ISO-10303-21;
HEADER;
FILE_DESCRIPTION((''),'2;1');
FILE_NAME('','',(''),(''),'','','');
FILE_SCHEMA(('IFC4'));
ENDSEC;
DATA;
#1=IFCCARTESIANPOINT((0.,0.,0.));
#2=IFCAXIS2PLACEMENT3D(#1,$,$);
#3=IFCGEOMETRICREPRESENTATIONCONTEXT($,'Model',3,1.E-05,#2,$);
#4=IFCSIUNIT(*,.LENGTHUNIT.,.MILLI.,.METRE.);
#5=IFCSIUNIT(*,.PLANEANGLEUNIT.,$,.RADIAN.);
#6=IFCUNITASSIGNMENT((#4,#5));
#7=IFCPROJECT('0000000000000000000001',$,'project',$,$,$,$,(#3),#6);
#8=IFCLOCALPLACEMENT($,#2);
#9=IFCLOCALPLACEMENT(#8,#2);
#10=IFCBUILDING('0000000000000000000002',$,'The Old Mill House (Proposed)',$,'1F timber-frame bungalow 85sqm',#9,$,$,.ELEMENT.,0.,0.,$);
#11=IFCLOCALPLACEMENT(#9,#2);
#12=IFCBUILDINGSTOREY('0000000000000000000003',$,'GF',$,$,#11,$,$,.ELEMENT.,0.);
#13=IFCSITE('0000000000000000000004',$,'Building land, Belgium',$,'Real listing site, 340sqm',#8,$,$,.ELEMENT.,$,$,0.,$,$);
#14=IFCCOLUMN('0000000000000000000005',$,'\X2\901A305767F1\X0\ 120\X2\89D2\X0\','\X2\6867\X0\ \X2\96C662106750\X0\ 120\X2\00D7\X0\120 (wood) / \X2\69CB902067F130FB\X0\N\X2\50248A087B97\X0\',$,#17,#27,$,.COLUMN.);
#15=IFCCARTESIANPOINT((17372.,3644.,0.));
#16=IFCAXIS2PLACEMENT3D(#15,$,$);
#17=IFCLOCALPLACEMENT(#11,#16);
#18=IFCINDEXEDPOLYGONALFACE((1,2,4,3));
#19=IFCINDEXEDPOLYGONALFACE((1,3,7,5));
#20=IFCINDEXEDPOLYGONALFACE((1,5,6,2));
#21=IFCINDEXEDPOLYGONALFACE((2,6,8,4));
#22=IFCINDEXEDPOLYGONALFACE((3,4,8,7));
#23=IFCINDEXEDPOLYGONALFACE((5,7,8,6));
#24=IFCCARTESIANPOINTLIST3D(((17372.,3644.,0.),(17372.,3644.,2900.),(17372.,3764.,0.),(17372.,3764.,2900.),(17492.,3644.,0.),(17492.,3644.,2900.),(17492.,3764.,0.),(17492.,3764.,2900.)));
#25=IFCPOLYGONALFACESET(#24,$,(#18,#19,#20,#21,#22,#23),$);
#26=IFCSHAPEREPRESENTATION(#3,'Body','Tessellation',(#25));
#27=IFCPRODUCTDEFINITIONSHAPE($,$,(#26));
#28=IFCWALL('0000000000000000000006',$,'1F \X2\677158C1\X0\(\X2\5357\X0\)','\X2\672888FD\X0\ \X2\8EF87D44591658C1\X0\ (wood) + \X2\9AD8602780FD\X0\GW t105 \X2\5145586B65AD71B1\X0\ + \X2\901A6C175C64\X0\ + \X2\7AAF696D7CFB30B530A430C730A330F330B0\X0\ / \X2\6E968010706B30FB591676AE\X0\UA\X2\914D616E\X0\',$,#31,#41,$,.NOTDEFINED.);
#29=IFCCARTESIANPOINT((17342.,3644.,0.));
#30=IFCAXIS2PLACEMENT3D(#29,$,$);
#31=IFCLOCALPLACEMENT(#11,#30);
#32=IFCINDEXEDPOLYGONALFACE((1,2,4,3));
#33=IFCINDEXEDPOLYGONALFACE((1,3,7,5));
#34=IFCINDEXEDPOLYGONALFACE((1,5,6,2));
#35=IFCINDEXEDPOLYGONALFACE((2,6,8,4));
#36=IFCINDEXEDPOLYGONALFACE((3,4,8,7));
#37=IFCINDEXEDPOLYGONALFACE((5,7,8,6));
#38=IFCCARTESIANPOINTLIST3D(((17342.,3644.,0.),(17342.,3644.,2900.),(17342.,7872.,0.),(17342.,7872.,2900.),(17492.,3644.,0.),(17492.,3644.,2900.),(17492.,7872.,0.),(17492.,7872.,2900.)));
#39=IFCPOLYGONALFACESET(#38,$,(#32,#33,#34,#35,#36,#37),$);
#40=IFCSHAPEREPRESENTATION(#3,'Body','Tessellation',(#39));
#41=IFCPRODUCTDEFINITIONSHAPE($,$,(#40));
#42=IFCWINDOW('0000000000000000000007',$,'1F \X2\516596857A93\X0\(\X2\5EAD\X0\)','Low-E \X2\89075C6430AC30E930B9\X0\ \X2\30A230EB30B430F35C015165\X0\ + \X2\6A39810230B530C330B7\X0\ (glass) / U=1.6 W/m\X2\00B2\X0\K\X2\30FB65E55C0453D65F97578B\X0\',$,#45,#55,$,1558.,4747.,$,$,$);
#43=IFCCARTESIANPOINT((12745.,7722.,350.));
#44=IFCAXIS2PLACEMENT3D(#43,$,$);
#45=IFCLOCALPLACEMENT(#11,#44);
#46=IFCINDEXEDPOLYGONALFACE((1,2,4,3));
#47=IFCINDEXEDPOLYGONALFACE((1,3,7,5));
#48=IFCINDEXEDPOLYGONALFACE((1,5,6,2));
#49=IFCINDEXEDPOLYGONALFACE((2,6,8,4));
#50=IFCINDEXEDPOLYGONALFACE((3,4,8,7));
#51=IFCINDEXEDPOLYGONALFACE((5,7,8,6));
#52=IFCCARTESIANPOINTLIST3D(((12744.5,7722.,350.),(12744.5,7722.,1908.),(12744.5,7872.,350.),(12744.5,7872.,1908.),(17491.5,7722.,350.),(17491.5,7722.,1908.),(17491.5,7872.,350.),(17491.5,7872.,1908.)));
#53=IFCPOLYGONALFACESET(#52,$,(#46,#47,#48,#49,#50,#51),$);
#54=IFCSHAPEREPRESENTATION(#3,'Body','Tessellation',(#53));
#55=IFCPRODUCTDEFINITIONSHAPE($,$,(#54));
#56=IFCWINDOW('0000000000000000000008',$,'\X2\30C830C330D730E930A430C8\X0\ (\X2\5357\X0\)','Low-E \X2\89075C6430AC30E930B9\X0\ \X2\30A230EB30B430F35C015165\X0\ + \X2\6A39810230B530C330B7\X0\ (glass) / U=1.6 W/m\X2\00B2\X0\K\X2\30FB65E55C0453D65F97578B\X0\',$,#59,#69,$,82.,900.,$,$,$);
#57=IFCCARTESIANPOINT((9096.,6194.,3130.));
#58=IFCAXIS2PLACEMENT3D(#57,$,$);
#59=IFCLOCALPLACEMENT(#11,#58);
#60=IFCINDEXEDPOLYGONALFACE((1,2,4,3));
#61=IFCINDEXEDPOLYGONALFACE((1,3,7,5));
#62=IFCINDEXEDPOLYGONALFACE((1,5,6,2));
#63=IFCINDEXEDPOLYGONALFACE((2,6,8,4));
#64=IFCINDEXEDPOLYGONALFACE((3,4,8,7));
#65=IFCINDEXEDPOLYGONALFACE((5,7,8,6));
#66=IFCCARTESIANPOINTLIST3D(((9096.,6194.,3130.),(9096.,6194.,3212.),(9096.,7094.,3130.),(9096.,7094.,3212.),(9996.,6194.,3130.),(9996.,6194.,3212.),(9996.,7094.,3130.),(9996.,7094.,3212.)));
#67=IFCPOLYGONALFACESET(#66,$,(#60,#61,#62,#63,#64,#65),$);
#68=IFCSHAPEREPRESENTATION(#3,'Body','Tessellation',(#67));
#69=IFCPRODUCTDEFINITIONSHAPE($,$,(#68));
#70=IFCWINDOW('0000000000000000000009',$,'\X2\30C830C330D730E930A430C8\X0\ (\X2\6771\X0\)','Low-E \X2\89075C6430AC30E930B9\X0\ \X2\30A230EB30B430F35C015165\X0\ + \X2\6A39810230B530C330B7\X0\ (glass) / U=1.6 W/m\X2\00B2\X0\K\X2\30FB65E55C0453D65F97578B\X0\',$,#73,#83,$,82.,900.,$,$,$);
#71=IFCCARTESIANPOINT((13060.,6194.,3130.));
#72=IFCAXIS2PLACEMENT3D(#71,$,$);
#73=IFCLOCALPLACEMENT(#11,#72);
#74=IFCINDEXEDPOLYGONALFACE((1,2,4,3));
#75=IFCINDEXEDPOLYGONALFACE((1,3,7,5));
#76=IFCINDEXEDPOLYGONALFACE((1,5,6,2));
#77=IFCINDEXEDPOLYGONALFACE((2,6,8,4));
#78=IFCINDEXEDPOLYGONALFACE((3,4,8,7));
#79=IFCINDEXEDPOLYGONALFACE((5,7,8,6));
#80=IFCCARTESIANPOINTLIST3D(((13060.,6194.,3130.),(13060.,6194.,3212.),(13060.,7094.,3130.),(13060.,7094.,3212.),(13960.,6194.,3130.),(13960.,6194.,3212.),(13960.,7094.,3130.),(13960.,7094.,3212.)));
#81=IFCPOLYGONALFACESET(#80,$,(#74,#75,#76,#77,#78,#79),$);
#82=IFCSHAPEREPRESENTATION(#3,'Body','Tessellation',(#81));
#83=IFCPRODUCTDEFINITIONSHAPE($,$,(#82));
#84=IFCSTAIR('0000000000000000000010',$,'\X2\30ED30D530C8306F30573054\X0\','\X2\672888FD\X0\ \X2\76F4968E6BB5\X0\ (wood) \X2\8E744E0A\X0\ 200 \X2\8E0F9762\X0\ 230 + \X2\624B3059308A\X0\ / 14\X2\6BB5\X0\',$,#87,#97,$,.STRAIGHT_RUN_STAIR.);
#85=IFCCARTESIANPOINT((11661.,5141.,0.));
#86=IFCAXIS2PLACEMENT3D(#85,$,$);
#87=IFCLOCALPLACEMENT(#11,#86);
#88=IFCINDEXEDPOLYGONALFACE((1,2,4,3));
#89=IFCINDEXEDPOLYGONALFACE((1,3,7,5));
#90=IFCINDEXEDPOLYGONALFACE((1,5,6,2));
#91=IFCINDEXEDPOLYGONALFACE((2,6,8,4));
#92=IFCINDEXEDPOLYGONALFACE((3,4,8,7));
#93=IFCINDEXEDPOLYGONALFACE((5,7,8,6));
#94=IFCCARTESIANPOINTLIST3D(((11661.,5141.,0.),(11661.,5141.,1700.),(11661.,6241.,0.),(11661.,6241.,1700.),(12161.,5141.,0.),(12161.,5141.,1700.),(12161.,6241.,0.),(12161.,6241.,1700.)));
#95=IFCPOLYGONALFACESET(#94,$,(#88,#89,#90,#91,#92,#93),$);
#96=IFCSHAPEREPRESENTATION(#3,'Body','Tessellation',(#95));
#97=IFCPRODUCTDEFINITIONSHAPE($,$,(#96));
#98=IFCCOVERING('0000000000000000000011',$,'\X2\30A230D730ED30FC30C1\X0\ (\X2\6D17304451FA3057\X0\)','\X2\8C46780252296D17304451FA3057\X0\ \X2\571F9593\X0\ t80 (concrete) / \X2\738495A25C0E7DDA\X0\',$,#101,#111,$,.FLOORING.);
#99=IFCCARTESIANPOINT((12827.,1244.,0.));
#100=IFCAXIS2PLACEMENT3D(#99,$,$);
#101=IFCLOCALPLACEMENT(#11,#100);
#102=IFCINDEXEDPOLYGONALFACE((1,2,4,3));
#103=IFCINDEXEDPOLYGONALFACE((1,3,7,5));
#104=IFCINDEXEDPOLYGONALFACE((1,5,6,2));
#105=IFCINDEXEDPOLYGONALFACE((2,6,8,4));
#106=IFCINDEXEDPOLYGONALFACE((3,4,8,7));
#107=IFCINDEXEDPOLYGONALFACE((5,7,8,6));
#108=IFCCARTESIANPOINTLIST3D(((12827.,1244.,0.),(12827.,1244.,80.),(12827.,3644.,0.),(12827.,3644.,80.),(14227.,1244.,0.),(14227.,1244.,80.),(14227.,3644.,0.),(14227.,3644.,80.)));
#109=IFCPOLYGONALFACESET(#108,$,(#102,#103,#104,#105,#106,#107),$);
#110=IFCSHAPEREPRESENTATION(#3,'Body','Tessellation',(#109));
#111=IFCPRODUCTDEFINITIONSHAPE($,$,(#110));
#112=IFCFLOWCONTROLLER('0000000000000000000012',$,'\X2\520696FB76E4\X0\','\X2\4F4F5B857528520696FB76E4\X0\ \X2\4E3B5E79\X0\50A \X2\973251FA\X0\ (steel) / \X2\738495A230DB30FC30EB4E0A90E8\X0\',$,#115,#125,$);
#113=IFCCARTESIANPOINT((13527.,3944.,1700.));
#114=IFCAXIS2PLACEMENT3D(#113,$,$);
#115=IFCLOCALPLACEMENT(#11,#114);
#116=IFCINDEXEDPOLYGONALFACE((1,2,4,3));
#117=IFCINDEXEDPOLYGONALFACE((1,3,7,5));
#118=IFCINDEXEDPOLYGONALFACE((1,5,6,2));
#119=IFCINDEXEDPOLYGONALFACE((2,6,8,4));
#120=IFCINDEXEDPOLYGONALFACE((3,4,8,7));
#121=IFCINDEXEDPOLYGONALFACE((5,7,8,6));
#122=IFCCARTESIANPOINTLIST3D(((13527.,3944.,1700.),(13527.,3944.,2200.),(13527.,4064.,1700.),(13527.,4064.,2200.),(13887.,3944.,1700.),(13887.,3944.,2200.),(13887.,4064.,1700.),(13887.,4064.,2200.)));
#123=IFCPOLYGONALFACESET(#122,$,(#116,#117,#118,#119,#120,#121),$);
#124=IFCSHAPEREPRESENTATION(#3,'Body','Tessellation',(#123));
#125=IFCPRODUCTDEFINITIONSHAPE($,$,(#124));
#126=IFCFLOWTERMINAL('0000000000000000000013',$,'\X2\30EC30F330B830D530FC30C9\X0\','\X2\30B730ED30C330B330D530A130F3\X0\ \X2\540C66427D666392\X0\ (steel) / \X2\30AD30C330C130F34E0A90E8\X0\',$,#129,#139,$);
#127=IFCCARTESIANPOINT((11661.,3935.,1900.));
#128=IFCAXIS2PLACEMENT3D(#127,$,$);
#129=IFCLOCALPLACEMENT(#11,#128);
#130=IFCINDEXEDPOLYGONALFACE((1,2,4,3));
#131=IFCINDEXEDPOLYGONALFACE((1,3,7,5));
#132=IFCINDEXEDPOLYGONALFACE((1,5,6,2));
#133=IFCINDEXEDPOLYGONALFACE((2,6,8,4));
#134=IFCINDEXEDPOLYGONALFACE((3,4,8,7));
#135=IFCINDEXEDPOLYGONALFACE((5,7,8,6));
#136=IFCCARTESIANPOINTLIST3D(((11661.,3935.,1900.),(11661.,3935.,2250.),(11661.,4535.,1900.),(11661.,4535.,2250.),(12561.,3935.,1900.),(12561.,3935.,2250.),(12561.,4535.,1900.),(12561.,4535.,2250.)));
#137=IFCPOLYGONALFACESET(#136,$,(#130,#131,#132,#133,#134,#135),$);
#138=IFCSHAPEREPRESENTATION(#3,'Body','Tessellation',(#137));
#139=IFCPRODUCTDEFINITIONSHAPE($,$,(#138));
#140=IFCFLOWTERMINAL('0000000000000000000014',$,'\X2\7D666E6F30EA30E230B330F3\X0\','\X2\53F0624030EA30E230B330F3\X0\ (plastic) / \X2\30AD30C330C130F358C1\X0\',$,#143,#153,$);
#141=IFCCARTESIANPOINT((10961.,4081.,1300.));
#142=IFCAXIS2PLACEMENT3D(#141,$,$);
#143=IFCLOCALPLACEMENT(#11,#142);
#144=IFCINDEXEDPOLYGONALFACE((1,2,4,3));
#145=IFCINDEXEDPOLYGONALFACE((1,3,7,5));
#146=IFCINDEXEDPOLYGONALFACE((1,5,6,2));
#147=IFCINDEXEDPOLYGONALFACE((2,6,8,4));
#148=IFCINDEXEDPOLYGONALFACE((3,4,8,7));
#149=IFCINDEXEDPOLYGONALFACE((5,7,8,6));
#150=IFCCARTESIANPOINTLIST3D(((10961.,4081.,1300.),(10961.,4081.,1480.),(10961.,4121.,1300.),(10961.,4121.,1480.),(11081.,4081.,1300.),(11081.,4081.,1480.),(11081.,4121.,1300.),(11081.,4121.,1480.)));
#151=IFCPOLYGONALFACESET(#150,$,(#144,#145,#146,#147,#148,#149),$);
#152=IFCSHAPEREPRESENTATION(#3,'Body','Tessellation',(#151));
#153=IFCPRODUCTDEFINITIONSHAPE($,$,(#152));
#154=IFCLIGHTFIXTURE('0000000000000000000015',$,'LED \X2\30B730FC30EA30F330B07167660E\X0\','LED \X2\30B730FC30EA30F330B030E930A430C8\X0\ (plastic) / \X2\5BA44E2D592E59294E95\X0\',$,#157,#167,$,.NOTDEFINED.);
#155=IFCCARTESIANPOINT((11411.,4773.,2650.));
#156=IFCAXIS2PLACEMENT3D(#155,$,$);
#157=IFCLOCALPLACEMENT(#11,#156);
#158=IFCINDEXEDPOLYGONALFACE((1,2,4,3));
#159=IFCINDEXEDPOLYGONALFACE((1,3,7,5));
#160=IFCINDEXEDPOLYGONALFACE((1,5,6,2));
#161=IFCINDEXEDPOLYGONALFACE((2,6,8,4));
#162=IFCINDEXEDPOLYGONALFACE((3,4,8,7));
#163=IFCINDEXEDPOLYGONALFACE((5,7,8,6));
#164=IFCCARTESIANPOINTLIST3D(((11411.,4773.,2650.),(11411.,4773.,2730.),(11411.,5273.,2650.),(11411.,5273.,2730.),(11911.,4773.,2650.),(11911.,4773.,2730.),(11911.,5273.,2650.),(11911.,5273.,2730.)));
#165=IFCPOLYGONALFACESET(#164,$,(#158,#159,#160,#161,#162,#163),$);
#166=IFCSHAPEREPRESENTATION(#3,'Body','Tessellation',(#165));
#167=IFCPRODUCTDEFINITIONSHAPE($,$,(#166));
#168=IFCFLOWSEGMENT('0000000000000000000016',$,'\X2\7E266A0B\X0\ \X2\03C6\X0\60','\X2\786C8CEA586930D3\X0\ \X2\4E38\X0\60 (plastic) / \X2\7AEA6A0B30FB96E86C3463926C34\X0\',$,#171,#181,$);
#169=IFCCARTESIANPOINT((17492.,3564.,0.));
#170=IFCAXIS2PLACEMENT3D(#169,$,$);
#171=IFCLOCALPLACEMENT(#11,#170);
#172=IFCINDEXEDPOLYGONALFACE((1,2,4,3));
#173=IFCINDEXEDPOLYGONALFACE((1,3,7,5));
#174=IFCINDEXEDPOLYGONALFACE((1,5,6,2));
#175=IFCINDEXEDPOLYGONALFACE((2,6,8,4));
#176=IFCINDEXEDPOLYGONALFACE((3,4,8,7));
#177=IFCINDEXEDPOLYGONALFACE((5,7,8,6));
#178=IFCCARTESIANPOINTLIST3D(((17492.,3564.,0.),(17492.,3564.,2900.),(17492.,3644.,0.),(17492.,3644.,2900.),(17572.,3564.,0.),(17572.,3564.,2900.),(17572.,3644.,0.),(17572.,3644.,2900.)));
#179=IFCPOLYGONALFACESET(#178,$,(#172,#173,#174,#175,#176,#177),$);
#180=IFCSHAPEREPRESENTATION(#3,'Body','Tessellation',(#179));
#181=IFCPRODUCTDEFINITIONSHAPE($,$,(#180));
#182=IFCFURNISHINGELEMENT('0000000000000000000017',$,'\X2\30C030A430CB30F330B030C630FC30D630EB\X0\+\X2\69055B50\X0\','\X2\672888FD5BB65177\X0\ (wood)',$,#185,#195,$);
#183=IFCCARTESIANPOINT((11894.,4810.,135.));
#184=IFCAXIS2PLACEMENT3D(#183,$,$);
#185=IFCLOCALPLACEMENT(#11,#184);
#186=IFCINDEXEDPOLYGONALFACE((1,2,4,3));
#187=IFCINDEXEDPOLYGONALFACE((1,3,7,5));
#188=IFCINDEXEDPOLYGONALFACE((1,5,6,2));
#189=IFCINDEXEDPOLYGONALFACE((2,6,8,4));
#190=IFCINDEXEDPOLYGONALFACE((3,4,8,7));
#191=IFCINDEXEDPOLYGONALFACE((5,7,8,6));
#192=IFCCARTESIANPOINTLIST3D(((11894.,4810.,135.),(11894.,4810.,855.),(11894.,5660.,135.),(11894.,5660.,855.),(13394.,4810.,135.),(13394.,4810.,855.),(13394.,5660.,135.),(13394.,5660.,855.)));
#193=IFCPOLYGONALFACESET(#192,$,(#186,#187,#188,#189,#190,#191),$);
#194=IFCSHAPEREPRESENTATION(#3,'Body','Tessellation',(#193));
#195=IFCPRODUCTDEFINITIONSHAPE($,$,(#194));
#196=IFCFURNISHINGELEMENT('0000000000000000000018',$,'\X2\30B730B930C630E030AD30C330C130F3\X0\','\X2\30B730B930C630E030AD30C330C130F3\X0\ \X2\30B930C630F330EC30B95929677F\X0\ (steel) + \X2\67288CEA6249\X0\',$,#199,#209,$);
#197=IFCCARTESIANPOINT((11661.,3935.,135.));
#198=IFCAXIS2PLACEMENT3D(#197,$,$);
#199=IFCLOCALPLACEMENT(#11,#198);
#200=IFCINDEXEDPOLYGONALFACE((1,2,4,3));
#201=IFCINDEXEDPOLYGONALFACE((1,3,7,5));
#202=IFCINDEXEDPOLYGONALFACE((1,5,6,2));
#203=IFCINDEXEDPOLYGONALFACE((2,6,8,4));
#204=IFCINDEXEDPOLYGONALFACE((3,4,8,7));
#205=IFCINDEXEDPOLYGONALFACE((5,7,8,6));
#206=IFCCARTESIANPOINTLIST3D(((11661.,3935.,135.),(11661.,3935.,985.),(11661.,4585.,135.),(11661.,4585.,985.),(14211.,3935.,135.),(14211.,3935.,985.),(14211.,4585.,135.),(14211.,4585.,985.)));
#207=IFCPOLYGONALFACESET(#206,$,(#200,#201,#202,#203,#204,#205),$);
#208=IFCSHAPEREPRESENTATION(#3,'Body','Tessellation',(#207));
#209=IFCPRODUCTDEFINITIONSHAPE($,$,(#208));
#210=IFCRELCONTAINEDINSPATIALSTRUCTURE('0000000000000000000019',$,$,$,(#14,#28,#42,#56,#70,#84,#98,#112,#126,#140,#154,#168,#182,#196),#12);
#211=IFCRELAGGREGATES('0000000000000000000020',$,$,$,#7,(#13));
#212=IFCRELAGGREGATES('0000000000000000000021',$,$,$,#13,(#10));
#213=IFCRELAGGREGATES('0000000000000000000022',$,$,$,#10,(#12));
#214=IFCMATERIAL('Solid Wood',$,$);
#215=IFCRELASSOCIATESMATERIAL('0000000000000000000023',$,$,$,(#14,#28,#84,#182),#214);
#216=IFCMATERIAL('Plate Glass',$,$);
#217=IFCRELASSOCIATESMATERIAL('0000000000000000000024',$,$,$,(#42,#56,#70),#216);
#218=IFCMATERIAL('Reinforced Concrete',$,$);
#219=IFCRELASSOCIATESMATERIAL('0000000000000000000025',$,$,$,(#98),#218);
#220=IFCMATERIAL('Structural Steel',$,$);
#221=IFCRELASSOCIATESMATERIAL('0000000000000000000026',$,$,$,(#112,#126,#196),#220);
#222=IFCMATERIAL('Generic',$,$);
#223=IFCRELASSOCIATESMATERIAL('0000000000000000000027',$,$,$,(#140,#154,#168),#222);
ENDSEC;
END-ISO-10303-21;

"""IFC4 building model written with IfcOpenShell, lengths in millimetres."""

from ifc_helpers import new_model, si_unit, frame, frame_2d, origin, place, context, project, spatial, rectangle, extrude, material, element, fill, save


model = new_model("IFC4")

# Units and contexts
model_context = context("Model", 3, precision=1e-05, world=origin())
ifc_project = project(units=[si_unit("LENGTHUNIT", "METRE", prefix="MILLI"), si_unit("PLANEANGLEUNIT", "RADIAN")], contexts=[model_context])

# Site, building, storey
site_placement = place(None, origin())
site = spatial("IfcSite", under=ifc_project, at=site_placement, Name="Building land, Belgium", ObjectType="Real listing site, 340sqm", CompositionType="ELEMENT", RefElevation=0.0)
building_placement = place(site_placement, origin())
building = spatial("IfcBuilding", under=site, at=building_placement, Name="The Old Mill House (Proposed)", ObjectType="1F timber-frame bungalow 85sqm", CompositionType="ELEMENT", ElevationOfRefHeight=0.0, ElevationOfTerrain=0.0)
storey_placement = place(building_placement, origin())
storey = spatial("IfcBuildingStorey", under=building, at=storey_placement, Name="GF", CompositionType="ELEMENT", Elevation=0.0)

# Column
ifc_material_1 = material(Name="Solid Wood")
column_1_placement = place(storey_placement, frame((17372.0, 3644.0, 0.0)))
element("IfcColumn", 1, at=column_1_placement, inside=storey, material=ifc_material_1, Name="通し柱 120角", Description="桧 集成材 120×120 (wood) / 構造柱・N値計算", PredefinedType="COLUMN", context=model_context, shape_type="SweptSolid", body=[
    extrude(rectangle(XDim=120.0, YDim=120.0, at=frame_2d((60.0, 60.0))), frame((17372.0, 3644.0, 0.0)), (0.0, 0.0, 1.0), 2900.0),
])

# Wall, opening, window
wall_1_placement = place(storey_placement, frame((17342.0, 3644.0, 0.0)))
wall_1 = element("IfcWall", 2, at=wall_1_placement, inside=storey, material=ifc_material_1, Name="1F 東壁(南)", Description="木製 軸組外壁 (wood) + 高性能GW t105 充填断熱 + 通気層 + 窯業系サイディング / 準耐火・外皮UA配慮", PredefinedType="NOTDEFINED", context=model_context, shape_type="SweptSolid", body=[
    extrude(rectangle(XDim=150.0, YDim=4228.0, at=frame_2d((75.0, 2114.0))), frame((17342.0, 3644.0, 0.0)), (0.0, 0.0, 1.0), 2900.0),
])
opening_1_placement = place(storey_placement, frame((12745.0, 7722.0, 350.0)))
opening_1 = element("IfcOpeningElement", 3, at=opening_1_placement, cuts=wall_1, PredefinedType="NOTDEFINED", context=model_context, shape_type="SweptSolid", body=[
    extrude(rectangle(XDim=4747.0, YDim=150.0, at=frame_2d((2373.0, 75.0))), frame((12745.0, 7722.0, 350.0)), (0.0, 0.0, 1.0), 1558.0),
])
ifc_material_2 = material(Name="Plate Glass")
window_1_placement = place(storey_placement, frame((12745.0, 7722.0, 350.0)))
window_1 = element("IfcWindow", 4, at=window_1_placement, inside=storey, material=ifc_material_2, Name="1F 入隅窓(庭)", Description="Low-E 複層ガラス アルゴン封入 + 樹脂サッシ (glass) / U=1.6 W/m²K・日射取得型", OverallHeight=1558.0, OverallWidth=4747.0, context=model_context, shape_type="SweptSolid", body=[
    extrude(rectangle(XDim=4747.0, YDim=150.0, at=frame_2d((2373.0, 75.0))), frame((12745.0, 7722.0, 350.0)), (0.0, 0.0, 1.0), 1558.0),
])
fill(opening_1, window_1)

# Windows
window_2_placement = place(storey_placement, frame((9096.0, 6194.0, 3130.0)))
element("IfcWindow", 5, at=window_2_placement, inside=storey, material=ifc_material_2, Name="トップライト (南)", Description="Low-E 複層ガラス アルゴン封入 + 樹脂サッシ (glass) / U=1.6 W/m²K・日射取得型", OverallHeight=82.0, OverallWidth=900.0, context=model_context, shape_type="SweptSolid", body=[
    extrude(rectangle(XDim=900.0, YDim=900.0, at=frame_2d((450.0, 450.0))), frame((9096.0, 6194.0, 3130.0)), (0.0, 0.0, 1.0), 82.0),
])
window_3_placement = place(storey_placement, frame((13060.0, 6194.0, 3130.0)))
element("IfcWindow", 6, at=window_3_placement, inside=storey, material=ifc_material_2, Name="トップライト (東)", Description="Low-E 複層ガラス アルゴン封入 + 樹脂サッシ (glass) / U=1.6 W/m²K・日射取得型", OverallHeight=82.0, OverallWidth=900.0, context=model_context, shape_type="SweptSolid", body=[
    extrude(rectangle(XDim=900.0, YDim=900.0, at=frame_2d((450.0, 450.0))), frame((13060.0, 6194.0, 3130.0)), (0.0, 0.0, 1.0), 82.0),
])

# Stair
stair_placement = place(storey_placement, frame((11661.0, 5141.0, 0.0)))
element("IfcStair", 7, at=stair_placement, inside=storey, material=ifc_material_1, Name="ロフトはしご", Description="木製 直階段 (wood) 蹴上 200 踏面 230 + 手すり / 14段", PredefinedType="STRAIGHT_RUN_STAIR", context=model_context, shape_type="SweptSolid", body=[
    extrude(rectangle(XDim=500.0, YDim=1100.0, at=frame_2d((250.0, 550.0))), frame((11661.0, 5141.0, 0.0)), (0.0, 0.0, 1.0), 1700.0),
])

# Covering
ifc_material_3 = material(Name="Reinforced Concrete")
covering_placement = place(storey_placement, frame((12827.0, 1244.0, 0.0)))
element("IfcCovering", 8, at=covering_placement, inside=storey, material=ifc_material_3, Name="アプローチ (洗い出し)", Description="豆砂利洗い出し 土間 t80 (concrete) / 玄関導線", PredefinedType="FLOORING", context=model_context, shape_type="SweptSolid", body=[
    extrude(rectangle(XDim=1400.0, YDim=2400.0, at=frame_2d((700.0, 1200.0))), frame((12827.0, 1244.0, 0.0)), (0.0, 0.0, 1.0), 80.0),
])

# Flow controller
ifc_material_4 = material(Name="Structural Steel")
flow_controller_placement = place(storey_placement, frame((13527.0, 3944.0, 1700.0)))
element("IfcFlowController", 9, at=flow_controller_placement, inside=storey, material=ifc_material_4, Name="分電盤", Description="住宅用分電盤 主幹50A 露出 (steel) / 玄関ホール上部", context=model_context, shape_type="SweptSolid", body=[
    extrude(rectangle(XDim=360.0, YDim=120.0, at=frame_2d((180.0, 60.0))), frame((13527.0, 3944.0, 1700.0)), (0.0, 0.0, 1.0), 500.0),
])

# Flow terminals
flow_terminal_1_placement = place(storey_placement, frame((11661.0, 3935.0, 1900.0)))
element("IfcFlowTerminal", 10, at=flow_terminal_1_placement, inside=storey, material=ifc_material_4, Name="レンジフード", Description="シロッコファン 同時給排 (steel) / キッチン上部", context=model_context, shape_type="SweptSolid", body=[
    extrude(rectangle(XDim=900.0, YDim=600.0, at=frame_2d((450.0, 300.0))), frame((11661.0, 3935.0, 1900.0)), (0.0, 0.0, 1.0), 350.0),
])
ifc_material_5 = material(Name="Generic")
flow_terminal_2_placement = place(storey_placement, frame((10961.0, 4081.0, 1300.0)))
element("IfcFlowTerminal", 11, at=flow_terminal_2_placement, inside=storey, material=ifc_material_5, Name="給湯リモコン", Description="台所リモコン (plastic) / キッチン壁", context=model_context, shape_type="SweptSolid", body=[
    extrude(rectangle(XDim=120.0, YDim=40.0, at=frame_2d((60.0, 20.0))), frame((10961.0, 4081.0, 1300.0)), (0.0, 0.0, 1.0), 180.0),
])

# Light fixture
light_fixture_placement = place(storey_placement, frame((11411.0, 4773.0, 2650.0)))
element("IfcLightFixture", 12, at=light_fixture_placement, inside=storey, material=ifc_material_5, Name="LED シーリング照明", Description="LED シーリングライト (plastic) / 室中央天井", PredefinedType="NOTDEFINED", context=model_context, shape_type="SweptSolid", body=[
    extrude(rectangle(XDim=500.0, YDim=500.0, at=frame_2d((250.0, 250.0))), frame((11411.0, 4773.0, 2650.0)), (0.0, 0.0, 1.0), 80.0),
])

# Flow segment
flow_segment_placement = place(storey_placement, frame((17492.0, 3564.0, 0.0)))
element("IfcFlowSegment", 13, at=flow_segment_placement, inside=storey, material=ifc_material_5, Name="縦樋 φ60", Description="硬質塩ビ 丸60 (plastic) / 竪樋・雨水排水", context=model_context, shape_type="SweptSolid", body=[
    extrude(rectangle(XDim=80.0, YDim=80.0, at=frame_2d((40.0, 40.0))), frame((17492.0, 3564.0, 0.0)), (0.0, 0.0, 1.0), 2900.0),
])

# Furnishing elements
furnishing_1_placement = place(storey_placement, frame((11894.0, 4810.0, 135.0)))
element("IfcFurnishingElement", 14, at=furnishing_1_placement, inside=storey, material=ifc_material_1, Name="ダイニングテーブル+椅子", Description="木製家具 (wood)", context=model_context, shape_type="SweptSolid", body=[
    extrude(rectangle(XDim=1500.0, YDim=850.0, at=frame_2d((750.0, 425.0))), frame((11894.0, 4810.0, 135.0)), (0.0, 0.0, 1.0), 720.0),
])
furnishing_2_placement = place(storey_placement, frame((11661.0, 3935.0, 135.0)))
element("IfcFurnishingElement", 15, at=furnishing_2_placement, inside=storey, material=ifc_material_4, Name="システムキッチン", Description="システムキッチン ステンレス天板 (steel) + 木質扉", context=model_context, shape_type="SweptSolid", body=[
    extrude(rectangle(XDim=2550.0, YDim=650.0, at=frame_2d((1275.0, 325.0))), frame((11661.0, 3935.0, 135.0)), (0.0, 0.0, 1.0), 850.0),
])

save(model, "model.ifc")
